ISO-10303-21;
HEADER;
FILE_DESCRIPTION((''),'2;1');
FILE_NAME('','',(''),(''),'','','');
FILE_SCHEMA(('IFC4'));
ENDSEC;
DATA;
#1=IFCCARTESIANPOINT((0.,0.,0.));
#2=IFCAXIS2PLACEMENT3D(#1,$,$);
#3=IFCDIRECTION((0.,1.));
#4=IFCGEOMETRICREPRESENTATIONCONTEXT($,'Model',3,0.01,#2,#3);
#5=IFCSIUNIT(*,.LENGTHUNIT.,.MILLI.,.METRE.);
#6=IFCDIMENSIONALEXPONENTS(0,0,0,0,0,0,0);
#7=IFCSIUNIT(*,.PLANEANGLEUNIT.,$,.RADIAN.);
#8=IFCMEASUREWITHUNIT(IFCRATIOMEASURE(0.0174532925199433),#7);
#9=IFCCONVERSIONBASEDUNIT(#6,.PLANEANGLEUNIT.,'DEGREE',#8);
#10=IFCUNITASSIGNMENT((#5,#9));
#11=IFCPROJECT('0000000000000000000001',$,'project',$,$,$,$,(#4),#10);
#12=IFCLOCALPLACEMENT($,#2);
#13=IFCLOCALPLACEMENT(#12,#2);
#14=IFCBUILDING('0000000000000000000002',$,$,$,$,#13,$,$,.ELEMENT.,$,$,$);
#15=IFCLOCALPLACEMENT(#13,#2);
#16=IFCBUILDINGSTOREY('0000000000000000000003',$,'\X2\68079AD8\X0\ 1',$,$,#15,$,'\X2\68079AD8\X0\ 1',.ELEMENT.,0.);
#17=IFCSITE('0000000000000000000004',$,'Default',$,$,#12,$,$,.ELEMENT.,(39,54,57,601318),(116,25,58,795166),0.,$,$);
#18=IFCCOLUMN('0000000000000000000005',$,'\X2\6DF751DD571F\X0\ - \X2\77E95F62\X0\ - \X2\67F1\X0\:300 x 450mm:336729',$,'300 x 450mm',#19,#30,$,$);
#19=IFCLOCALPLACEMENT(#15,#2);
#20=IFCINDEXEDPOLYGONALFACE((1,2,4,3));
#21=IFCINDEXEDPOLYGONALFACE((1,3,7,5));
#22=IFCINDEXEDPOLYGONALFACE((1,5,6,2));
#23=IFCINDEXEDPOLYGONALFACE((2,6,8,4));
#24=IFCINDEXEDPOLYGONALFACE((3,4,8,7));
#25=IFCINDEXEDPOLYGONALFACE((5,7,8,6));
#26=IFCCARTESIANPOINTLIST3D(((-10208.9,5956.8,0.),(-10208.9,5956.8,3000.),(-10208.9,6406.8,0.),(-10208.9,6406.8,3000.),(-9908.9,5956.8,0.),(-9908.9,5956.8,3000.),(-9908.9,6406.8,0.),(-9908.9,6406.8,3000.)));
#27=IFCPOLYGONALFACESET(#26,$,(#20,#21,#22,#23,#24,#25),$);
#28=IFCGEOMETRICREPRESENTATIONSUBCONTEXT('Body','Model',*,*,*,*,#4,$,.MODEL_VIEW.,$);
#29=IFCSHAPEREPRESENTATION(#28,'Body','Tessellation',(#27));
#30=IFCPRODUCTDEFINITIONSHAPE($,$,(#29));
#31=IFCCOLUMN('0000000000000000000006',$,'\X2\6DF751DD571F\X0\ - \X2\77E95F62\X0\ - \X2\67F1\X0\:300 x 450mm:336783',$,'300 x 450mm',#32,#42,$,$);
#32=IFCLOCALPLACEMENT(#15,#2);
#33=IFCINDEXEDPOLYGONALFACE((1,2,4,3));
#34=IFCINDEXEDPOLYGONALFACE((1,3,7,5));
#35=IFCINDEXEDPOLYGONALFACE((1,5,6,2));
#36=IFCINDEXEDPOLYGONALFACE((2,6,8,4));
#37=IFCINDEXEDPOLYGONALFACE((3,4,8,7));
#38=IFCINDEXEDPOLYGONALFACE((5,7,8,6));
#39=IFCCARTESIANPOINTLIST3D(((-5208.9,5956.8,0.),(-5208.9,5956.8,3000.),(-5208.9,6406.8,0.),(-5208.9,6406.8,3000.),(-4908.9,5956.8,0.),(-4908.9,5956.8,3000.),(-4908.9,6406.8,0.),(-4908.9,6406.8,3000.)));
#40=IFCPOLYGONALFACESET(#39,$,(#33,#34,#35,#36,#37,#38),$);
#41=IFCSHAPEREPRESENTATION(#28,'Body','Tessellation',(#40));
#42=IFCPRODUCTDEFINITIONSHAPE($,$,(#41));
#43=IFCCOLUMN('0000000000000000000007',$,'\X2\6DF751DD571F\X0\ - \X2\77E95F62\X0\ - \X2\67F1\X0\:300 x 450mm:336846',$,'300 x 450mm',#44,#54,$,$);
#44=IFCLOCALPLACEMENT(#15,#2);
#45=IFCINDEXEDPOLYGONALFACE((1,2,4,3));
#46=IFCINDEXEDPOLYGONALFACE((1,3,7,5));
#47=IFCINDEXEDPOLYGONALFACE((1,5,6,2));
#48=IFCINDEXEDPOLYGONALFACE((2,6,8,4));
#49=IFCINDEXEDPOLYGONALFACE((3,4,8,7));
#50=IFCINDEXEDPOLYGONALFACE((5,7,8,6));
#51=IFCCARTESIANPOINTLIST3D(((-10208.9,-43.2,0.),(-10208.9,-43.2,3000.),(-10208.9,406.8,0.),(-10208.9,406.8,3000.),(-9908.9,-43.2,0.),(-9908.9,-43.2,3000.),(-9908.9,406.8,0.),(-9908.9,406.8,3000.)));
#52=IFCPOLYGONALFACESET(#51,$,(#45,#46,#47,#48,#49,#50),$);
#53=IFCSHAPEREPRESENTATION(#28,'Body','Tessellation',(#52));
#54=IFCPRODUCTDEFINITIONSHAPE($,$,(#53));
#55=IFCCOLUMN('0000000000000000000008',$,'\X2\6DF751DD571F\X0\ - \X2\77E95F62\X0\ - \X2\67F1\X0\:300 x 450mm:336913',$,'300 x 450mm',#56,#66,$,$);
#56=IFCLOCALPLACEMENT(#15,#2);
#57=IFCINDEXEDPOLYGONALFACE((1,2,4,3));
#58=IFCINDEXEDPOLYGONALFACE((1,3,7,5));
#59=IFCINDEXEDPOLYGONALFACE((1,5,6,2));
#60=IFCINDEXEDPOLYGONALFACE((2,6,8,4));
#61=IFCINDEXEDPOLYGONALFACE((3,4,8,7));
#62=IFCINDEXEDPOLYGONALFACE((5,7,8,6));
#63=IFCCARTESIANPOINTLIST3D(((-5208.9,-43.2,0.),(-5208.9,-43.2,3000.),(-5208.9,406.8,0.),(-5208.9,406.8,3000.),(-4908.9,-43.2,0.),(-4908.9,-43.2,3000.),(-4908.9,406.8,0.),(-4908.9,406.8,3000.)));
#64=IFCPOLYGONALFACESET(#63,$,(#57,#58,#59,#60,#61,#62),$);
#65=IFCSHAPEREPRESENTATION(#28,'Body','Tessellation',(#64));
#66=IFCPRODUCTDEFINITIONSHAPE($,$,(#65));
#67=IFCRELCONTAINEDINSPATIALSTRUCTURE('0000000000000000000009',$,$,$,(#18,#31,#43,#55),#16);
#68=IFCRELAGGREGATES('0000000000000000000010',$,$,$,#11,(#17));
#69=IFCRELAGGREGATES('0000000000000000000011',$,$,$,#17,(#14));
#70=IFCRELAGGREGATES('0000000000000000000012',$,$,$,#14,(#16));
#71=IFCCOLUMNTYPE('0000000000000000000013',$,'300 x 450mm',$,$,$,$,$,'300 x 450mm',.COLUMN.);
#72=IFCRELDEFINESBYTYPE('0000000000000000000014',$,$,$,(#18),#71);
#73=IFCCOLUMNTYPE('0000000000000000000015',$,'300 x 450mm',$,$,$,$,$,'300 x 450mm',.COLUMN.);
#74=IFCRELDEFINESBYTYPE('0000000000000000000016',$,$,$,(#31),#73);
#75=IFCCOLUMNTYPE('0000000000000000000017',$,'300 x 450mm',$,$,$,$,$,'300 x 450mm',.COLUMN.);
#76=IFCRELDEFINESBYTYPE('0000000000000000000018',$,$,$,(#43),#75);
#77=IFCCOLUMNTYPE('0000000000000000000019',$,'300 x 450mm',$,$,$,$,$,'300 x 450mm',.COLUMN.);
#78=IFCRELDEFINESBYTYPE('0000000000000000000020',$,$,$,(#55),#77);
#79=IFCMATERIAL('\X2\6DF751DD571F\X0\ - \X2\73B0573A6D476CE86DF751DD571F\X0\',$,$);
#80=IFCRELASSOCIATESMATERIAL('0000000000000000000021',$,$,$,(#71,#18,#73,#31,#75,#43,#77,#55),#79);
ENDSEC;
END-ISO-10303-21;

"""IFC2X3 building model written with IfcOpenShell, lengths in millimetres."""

from ifc_helpers import new_model, entity, si_unit, converted_unit, direction, frame, frame_2d, origin, origin_2d_with_axis, place, context, subcontext, project, spatial, rectangle, extrude, source, transform, mapped, material, type_object, type_shapes, element, save


model = new_model("IFC2X3")

# Units and contexts
model_context = context("Model", 3, precision=0.01, world=origin(), true_north=direction((0.0, 1.0)))
body_context = subcontext(model_context, "Body", "Model", "MODEL_VIEW")
ifc_project = project(units=[si_unit("LENGTHUNIT", "METRE", prefix="MILLI"), converted_unit("PLANEANGLEUNIT", "DEGREE", entity("IfcRatioMeasure", 0.0174532925199433), si_unit("PLANEANGLEUNIT", "RADIAN"), dimensions=[0, 0, 0, 0, 0, 0, 0])], contexts=[model_context])

# Site, building, storey
site_placement = place(None, origin())
site = spatial("IfcSite", under=ifc_project, at=site_placement, Name="Default", CompositionType="ELEMENT", RefLatitude=(39, 54, 57, 601318), RefLongitude=(116, 25, 58, 795166), RefElevation=0.0)
building_placement = place(site_placement, origin())
building = spatial("IfcBuilding", under=site, at=building_placement, CompositionType="ELEMENT")
storey_placement = place(building_placement, origin())
storey = spatial("IfcBuildingStorey", under=building, at=storey_placement, Name="标高 1", LongName="标高 1", CompositionType="ELEMENT", Elevation=0.0)

# Columns
ifc_material = material(Name="混凝土 - 现场浇注混凝土")
column_type_1 = type_object("IfcColumnType", Name="300 x 450mm", ElementType="300 x 450mm", PredefinedType="COLUMN", material=ifc_material)
shared_shape_1 = source(origin(), body_context, "Body", "SweptSolid", [
    extrude(rectangle(XDim=450.0, YDim=300.0, at=origin_2d_with_axis()), frame((-10058.9, 6181.8, 0.0), z_axis=(0.0, 0.0, 1.0), x_axis=(0.0, -1.0, 0.0)), (0.0, 0.0, 1.0), 3000.0),
])
type_shapes(column_type_1, [shared_shape_1])
column_1_placement = place(storey_placement, origin())
element("IfcColumn", 1, at=column_1_placement, inside=storey, type_object=column_type_1, material=ifc_material, Name="混凝土 - 矩形 - 柱:300 x 450mm:336729", ObjectType="300 x 450mm", context=body_context, shape_type="MappedRepresentation", body=[
    mapped(shared_shape_1, transform((0.0, 0.0, 0.0), scale=1.0)),
])
column_type_2 = type_object("IfcColumnType", Name="300 x 450mm", ElementType="300 x 450mm", PredefinedType="COLUMN", material=ifc_material)
shared_shape_2 = source(origin(), body_context, "Body", "SweptSolid", [
    extrude(rectangle(XDim=450.0, YDim=300.0, at=frame_2d((0.0, 0.0), x_axis=(1.0, 0.0))), frame((-5058.9, 6181.8, 0.0), z_axis=(0.0, 0.0, 1.0), x_axis=(0.0, -1.0, 0.0)), (0.0, 0.0, 1.0), 3000.0),
])
type_shapes(column_type_2, [shared_shape_2])
column_2_placement = place(storey_placement, origin())
element("IfcColumn", 2, at=column_2_placement, inside=storey, type_object=column_type_2, material=ifc_material, Name="混凝土 - 矩形 - 柱:300 x 450mm:336783", ObjectType="300 x 450mm", context=body_context, shape_type="MappedRepresentation", body=[
    mapped(shared_shape_2, transform((0.0, 0.0, 0.0), scale=1.0)),
])
column_type_3 = type_object("IfcColumnType", Name="300 x 450mm", ElementType="300 x 450mm", PredefinedType="COLUMN", material=ifc_material)
shared_shape_3 = source(origin(), body_context, "Body", "SweptSolid", [
    extrude(rectangle(XDim=450.0, YDim=300.0, at=origin_2d_with_axis()), frame((-10058.9, 181.8, 0.0), z_axis=(0.0, 0.0, 1.0), x_axis=(0.0, -1.0, 0.0)), (0.0, 0.0, 1.0), 3000.0),
])
type_shapes(column_type_3, [shared_shape_3])
column_3_placement = place(storey_placement, origin())
element("IfcColumn", 3, at=column_3_placement, inside=storey, type_object=column_type_3, material=ifc_material, Name="混凝土 - 矩形 - 柱:300 x 450mm:336846", ObjectType="300 x 450mm", context=body_context, shape_type="MappedRepresentation", body=[
    mapped(shared_shape_3, transform((0.0, 0.0, 0.0), scale=1.0)),
])
column_type_4 = type_object("IfcColumnType", Name="300 x 450mm", ElementType="300 x 450mm", PredefinedType="COLUMN", material=ifc_material)
shared_shape_4 = source(origin(), body_context, "Body", "SweptSolid", [
    extrude(rectangle(XDim=450.0, YDim=300.0, at=frame_2d((0.0, 0.0), x_axis=(1.0, 0.0))), frame((-5058.9, 181.8, 0.0), z_axis=(0.0, 0.0, 1.0), x_axis=(0.0, -1.0, 0.0)), (0.0, 0.0, 1.0), 3000.0),
])
type_shapes(column_type_4, [shared_shape_4])
column_4_placement = place(storey_placement, origin())
element("IfcColumn", 4, at=column_4_placement, inside=storey, type_object=column_type_4, material=ifc_material, Name="混凝土 - 矩形 - 柱:300 x 450mm:336913", ObjectType="300 x 450mm", context=body_context, shape_type="MappedRepresentation", body=[
    mapped(shared_shape_4, transform((0.0, 0.0, 0.0), scale=1.0)),
])

save(model, "model.ifc")
